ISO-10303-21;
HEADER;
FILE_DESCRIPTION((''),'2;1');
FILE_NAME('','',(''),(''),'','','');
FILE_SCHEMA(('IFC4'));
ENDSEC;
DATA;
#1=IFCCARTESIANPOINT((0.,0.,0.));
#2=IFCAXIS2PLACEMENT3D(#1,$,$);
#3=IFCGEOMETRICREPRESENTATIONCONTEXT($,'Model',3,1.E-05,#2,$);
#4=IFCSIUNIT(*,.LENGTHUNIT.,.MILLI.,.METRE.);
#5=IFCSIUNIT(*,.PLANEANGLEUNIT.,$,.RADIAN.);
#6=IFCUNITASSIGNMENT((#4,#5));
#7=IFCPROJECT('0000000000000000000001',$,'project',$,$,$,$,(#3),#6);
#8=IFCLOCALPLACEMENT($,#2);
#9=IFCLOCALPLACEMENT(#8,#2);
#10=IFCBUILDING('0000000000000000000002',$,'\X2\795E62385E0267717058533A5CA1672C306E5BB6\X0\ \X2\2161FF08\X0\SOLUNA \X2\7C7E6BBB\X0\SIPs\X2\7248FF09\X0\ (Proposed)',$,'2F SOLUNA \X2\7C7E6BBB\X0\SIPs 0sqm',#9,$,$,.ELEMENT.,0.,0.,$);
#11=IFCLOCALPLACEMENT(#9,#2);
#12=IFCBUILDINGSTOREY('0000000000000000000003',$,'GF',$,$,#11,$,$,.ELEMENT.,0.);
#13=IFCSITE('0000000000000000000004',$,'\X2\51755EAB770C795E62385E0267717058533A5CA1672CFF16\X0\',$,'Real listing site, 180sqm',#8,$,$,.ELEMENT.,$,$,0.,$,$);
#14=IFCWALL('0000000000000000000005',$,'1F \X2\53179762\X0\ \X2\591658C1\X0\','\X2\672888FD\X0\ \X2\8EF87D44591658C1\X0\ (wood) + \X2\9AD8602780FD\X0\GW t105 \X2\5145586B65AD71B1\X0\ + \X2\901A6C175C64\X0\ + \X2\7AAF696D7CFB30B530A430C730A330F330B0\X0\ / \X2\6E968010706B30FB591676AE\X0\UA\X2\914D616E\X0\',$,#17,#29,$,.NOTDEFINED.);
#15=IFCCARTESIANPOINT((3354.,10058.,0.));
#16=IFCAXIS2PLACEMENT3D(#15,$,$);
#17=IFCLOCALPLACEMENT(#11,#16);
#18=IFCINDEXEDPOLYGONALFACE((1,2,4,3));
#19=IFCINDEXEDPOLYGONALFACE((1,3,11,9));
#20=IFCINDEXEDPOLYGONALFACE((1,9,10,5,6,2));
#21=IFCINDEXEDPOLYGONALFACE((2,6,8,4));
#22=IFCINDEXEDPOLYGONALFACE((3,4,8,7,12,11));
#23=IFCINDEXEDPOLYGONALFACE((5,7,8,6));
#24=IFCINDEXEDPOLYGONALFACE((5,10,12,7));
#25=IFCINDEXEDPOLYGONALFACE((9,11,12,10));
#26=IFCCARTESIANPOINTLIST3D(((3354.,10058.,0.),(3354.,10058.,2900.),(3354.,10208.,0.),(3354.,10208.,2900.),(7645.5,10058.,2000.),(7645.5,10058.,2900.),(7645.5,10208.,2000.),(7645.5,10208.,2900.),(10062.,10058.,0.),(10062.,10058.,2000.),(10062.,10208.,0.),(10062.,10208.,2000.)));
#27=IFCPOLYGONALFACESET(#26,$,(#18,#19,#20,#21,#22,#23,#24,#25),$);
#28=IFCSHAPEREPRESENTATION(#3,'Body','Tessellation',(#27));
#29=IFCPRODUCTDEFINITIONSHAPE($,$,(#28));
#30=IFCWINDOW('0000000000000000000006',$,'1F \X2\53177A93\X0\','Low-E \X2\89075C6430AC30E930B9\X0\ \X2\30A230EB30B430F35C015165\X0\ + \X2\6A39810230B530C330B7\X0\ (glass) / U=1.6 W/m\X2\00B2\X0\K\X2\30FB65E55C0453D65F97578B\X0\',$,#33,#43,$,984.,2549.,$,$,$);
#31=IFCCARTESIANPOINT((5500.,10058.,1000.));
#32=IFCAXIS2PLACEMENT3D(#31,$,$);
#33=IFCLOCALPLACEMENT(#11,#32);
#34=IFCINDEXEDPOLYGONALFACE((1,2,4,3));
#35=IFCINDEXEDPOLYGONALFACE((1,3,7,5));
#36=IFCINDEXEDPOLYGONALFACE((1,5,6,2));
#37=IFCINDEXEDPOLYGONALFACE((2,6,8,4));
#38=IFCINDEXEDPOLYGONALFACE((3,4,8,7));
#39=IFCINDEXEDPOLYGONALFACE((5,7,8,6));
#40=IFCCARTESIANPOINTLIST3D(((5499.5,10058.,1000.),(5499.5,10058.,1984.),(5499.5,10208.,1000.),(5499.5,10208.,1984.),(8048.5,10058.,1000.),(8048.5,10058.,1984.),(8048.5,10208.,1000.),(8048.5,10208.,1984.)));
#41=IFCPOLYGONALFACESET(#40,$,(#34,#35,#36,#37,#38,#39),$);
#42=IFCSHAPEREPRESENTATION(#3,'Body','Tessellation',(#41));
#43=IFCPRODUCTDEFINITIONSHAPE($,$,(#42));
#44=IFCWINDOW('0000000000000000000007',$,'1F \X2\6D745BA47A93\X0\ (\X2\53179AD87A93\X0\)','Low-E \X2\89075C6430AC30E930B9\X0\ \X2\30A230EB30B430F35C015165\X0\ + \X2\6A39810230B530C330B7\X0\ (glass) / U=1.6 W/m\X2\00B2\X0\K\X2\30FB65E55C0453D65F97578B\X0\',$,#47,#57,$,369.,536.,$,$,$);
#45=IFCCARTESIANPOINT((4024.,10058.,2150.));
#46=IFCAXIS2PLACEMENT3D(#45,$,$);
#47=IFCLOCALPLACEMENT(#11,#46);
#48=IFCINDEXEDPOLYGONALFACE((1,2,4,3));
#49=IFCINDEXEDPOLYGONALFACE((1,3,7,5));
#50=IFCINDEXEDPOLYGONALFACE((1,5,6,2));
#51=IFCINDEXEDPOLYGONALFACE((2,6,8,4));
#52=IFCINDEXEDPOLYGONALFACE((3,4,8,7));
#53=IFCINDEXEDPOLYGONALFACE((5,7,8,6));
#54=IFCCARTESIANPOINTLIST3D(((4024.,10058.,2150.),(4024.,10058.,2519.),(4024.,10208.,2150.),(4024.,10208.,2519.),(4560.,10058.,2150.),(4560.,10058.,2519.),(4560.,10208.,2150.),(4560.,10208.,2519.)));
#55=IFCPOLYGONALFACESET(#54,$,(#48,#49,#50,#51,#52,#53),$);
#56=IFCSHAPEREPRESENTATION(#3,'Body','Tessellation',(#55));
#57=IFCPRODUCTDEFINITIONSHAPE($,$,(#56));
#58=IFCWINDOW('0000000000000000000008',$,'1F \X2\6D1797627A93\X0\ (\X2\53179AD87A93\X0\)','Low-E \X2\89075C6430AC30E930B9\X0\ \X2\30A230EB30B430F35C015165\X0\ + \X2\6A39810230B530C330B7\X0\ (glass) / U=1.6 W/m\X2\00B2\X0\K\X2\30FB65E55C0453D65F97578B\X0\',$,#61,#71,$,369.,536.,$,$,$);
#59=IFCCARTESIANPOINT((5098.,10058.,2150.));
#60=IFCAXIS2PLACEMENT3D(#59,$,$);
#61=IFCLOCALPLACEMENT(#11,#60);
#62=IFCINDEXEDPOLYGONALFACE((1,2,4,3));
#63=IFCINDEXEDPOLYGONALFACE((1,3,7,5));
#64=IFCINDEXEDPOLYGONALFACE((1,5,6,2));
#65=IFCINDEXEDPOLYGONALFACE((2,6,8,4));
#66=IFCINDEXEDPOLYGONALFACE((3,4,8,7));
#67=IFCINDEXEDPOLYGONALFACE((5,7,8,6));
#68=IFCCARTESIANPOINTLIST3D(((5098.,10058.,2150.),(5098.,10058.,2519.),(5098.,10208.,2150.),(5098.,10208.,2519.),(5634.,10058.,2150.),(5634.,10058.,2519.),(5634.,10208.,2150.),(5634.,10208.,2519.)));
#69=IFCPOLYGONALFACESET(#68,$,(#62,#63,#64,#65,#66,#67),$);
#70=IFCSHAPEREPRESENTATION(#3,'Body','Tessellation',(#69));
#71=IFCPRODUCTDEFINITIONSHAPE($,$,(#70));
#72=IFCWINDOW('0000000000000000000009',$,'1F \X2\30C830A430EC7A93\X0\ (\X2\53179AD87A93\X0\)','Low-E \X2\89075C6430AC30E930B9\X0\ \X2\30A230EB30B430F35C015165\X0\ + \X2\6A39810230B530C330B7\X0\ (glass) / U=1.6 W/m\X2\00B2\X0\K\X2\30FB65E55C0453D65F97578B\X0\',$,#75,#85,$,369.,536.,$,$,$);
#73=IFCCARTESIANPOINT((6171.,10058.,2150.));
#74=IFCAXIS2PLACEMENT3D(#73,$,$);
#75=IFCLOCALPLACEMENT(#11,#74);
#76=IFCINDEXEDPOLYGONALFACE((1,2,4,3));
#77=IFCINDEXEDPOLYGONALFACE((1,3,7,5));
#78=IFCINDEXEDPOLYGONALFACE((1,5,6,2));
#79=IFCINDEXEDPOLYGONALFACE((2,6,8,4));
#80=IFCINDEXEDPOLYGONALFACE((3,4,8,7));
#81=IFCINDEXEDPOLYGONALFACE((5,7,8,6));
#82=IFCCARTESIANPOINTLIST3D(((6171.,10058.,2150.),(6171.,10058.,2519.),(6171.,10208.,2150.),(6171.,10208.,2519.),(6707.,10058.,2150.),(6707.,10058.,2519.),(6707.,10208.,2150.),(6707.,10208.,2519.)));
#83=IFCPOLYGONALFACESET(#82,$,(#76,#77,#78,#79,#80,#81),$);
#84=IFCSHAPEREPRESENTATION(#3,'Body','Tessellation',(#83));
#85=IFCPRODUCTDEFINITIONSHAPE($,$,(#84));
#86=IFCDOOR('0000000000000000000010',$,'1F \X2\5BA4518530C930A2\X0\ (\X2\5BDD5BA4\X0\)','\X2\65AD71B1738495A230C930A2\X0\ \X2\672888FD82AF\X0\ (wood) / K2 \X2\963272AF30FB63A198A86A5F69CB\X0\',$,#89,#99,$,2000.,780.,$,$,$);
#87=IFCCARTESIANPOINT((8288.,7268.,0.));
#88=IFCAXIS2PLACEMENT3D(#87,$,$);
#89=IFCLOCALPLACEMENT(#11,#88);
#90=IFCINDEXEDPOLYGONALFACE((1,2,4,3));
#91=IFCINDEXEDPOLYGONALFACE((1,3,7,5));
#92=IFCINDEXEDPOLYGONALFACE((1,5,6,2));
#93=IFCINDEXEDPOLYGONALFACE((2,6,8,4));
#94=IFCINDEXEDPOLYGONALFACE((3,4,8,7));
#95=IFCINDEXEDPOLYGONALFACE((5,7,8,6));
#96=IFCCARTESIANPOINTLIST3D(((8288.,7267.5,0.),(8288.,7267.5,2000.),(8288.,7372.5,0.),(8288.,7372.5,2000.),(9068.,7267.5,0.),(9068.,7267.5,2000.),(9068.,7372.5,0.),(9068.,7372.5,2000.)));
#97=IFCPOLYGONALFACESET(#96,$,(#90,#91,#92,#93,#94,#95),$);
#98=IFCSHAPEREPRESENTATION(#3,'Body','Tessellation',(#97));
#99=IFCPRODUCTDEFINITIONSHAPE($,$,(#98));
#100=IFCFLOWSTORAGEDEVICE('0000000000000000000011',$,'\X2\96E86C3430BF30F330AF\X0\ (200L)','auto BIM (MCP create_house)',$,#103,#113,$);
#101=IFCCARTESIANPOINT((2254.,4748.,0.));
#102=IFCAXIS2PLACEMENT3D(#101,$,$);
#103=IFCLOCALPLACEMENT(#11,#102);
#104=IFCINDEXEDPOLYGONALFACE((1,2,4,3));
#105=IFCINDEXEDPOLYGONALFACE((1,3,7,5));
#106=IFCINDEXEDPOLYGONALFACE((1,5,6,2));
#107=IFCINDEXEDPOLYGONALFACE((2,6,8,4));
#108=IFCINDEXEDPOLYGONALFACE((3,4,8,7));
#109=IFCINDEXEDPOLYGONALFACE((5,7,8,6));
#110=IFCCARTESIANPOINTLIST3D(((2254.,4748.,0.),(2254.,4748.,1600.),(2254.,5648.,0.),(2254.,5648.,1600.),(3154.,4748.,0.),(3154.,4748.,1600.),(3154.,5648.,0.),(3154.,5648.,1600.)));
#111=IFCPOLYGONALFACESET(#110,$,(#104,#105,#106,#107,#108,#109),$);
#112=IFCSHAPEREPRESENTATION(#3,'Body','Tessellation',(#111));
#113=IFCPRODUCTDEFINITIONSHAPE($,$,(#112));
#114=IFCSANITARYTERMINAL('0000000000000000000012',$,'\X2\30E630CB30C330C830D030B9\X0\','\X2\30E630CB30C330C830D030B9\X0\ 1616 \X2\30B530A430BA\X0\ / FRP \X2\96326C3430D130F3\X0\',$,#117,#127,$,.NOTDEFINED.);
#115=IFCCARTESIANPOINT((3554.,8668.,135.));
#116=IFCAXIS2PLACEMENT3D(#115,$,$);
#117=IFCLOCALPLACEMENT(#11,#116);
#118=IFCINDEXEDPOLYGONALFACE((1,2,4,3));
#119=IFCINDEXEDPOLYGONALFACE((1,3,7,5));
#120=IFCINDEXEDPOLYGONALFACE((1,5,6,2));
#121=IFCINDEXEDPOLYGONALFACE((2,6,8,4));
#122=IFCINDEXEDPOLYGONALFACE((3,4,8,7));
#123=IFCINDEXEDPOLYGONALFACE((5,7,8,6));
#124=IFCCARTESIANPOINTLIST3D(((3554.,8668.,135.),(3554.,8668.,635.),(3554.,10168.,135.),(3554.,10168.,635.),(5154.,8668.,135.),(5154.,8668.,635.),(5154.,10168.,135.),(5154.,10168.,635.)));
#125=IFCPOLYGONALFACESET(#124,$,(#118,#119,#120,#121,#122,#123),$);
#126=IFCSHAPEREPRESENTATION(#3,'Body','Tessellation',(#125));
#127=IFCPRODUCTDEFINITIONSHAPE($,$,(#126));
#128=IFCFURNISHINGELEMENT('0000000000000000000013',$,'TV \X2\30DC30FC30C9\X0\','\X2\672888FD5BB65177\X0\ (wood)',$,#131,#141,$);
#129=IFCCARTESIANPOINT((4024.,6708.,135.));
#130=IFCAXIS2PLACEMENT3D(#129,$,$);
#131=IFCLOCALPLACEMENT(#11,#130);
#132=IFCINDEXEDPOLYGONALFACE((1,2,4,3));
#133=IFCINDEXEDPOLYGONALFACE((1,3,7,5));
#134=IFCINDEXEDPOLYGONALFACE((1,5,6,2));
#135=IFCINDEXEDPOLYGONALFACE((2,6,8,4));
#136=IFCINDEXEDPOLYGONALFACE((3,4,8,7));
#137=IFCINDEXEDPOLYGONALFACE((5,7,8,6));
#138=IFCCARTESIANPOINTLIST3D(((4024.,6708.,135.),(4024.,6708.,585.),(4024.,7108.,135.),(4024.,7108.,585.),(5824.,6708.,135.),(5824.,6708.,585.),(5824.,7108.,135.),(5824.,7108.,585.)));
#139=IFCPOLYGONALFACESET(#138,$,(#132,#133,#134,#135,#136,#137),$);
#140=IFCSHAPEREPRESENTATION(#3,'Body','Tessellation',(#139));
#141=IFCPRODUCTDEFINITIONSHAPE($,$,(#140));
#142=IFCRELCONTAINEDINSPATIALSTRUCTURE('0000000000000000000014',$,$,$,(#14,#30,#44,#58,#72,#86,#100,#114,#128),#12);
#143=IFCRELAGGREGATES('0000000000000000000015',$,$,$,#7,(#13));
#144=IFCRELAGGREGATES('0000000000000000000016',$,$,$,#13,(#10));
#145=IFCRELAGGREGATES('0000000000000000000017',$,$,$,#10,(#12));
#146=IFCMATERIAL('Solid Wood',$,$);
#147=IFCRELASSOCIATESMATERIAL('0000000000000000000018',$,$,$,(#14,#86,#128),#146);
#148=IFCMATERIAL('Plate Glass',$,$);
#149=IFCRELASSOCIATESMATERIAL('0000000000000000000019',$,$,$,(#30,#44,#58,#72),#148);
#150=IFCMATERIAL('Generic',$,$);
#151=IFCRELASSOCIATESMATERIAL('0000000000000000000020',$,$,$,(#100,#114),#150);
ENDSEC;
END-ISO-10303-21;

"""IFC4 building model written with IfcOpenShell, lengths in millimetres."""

from ifc_helpers import new_model, si_unit, frame, frame_2d, origin, place, context, project, spatial, rectangle, extrude, material, element, fill, save


model = new_model("IFC4")

# Units and contexts
model_context = context("Model", 3, precision=1e-05, world=origin())
ifc_project = project(units=[si_unit("LENGTHUNIT", "METRE", prefix="MILLI"), si_unit("PLANEANGLEUNIT", "RADIAN")], contexts=[model_context])

# Site, building, storey
site_placement = place(None, origin())
site = spatial("IfcSite", under=ifc_project, at=site_placement, Name="兵庫県神戸市東灘区岡本６", ObjectType="Real listing site, 180sqm", CompositionType="ELEMENT", RefElevation=0.0)
building_placement = place(site_placement, origin())
building = spatial("IfcBuilding", under=site, at=building_placement, Name="神戸市東灘区岡本の家 Ⅱ（SOLUNA 籾殻SIPs版） (Proposed)", ObjectType="2F SOLUNA 籾殻SIPs 0sqm", CompositionType="ELEMENT", ElevationOfRefHeight=0.0, ElevationOfTerrain=0.0)
storey_placement = place(building_placement, origin())
storey = spatial("IfcBuildingStorey", under=building, at=storey_placement, Name="GF", CompositionType="ELEMENT", Elevation=0.0)

# Wall, openings, windows
ifc_material_1 = material(Name="Solid Wood")
wall_1_placement = place(storey_placement, frame((3354.0, 10058.0, 0.0)))
wall_1 = element("IfcWall", 1, at=wall_1_placement, inside=storey, material=ifc_material_1, Name="1F 北面 外壁", Description="木製 軸組外壁 (wood) + 高性能GW t105 充填断熱 + 通気層 + 窯業系サイディング / 準耐火・外皮UA配慮", PredefinedType="NOTDEFINED", context=model_context, shape_type="SweptSolid", body=[
    extrude(rectangle(XDim=6708.0, YDim=150.0, at=frame_2d((3354.0, 75.0))), frame((3354.0, 10058.0, 0.0)), (0.0, 0.0, 1.0), 2900.0),
])
opening_1_placement = place(storey_placement, frame((5500.0, 10058.0, 1000.0)))
opening_1 = element("IfcOpeningElement", 2, at=opening_1_placement, cuts=wall_1, PredefinedType="NOTDEFINED", context=model_context, shape_type="SweptSolid", body=[
    extrude(rectangle(XDim=2549.0, YDim=150.0, at=frame_2d((1274.0, 75.0))), frame((5500.0, 10058.0, 1000.0)), (0.0, 0.0, 1.0), 984.0),
])
opening_2_placement = place(storey_placement, frame((4024.0, 10058.0, 2150.0)))
opening_2 = element("IfcOpeningElement", 3, at=opening_2_placement, cuts=wall_1, PredefinedType="NOTDEFINED", context=model_context, shape_type="SweptSolid", body=[
    extrude(rectangle(XDim=536.0, YDim=150.0, at=frame_2d((268.0, 75.0))), frame((4024.0, 10058.0, 2150.0)), (0.0, 0.0, 1.0), 369.0),
])
opening_3_placement = place(storey_placement, frame((5098.0, 10058.0, 2150.0)))
opening_3 = element("IfcOpeningElement", 4, at=opening_3_placement, cuts=wall_1, PredefinedType="NOTDEFINED", context=model_context, shape_type="SweptSolid", body=[
    extrude(rectangle(XDim=536.0, YDim=150.0, at=frame_2d((268.0, 75.0))), frame((5098.0, 10058.0, 2150.0)), (0.0, 0.0, 1.0), 369.0),
])
opening_4_placement = place(storey_placement, frame((6171.0, 10058.0, 2150.0)))
opening_4 = element("IfcOpeningElement", 5, at=opening_4_placement, cuts=wall_1, PredefinedType="NOTDEFINED", context=model_context, shape_type="SweptSolid", body=[
    extrude(rectangle(XDim=536.0, YDim=150.0, at=frame_2d((268.0, 75.0))), frame((6171.0, 10058.0, 2150.0)), (0.0, 0.0, 1.0), 369.0),
])
ifc_material_2 = material(Name="Plate Glass")
window_1_placement = place(storey_placement, frame((5500.0, 10058.0, 1000.0)))
window_1 = element("IfcWindow", 6, at=window_1_placement, inside=storey, material=ifc_material_2, Name="1F 北窓", Description="Low-E 複層ガラス アルゴン封入 + 樹脂サッシ (glass) / U=1.6 W/m²K・日射取得型", OverallHeight=984.0, OverallWidth=2549.0, context=model_context, shape_type="SweptSolid", body=[
    extrude(rectangle(XDim=2549.0, YDim=150.0, at=frame_2d((1274.0, 75.0))), frame((5500.0, 10058.0, 1000.0)), (0.0, 0.0, 1.0), 984.0),
])
fill(opening_1, window_1)
window_2_placement = place(storey_placement, frame((4024.0, 10058.0, 2150.0)))
window_2 = element("IfcWindow", 7, at=window_2_placement, inside=storey, material=ifc_material_2, Name="1F 浴室窓 (北高窓)", Description="Low-E 複層ガラス アルゴン封入 + 樹脂サッシ (glass) / U=1.6 W/m²K・日射取得型", OverallHeight=369.0, OverallWidth=536.0, context=model_context, shape_type="SweptSolid", body=[
    extrude(rectangle(XDim=536.0, YDim=150.0, at=frame_2d((268.0, 75.0))), frame((4024.0, 10058.0, 2150.0)), (0.0, 0.0, 1.0), 369.0),
])
fill(opening_2, window_2)
window_3_placement = place(storey_placement, frame((5098.0, 10058.0, 2150.0)))
window_3 = element("IfcWindow", 8, at=window_3_placement, inside=storey, material=ifc_material_2, Name="1F 洗面窓 (北高窓)", Description="Low-E 複層ガラス アルゴン封入 + 樹脂サッシ (glass) / U=1.6 W/m²K・日射取得型", OverallHeight=369.0, OverallWidth=536.0, context=model_context, shape_type="SweptSolid", body=[
    extrude(rectangle(XDim=536.0, YDim=150.0, at=frame_2d((268.0, 75.0))), frame((5098.0, 10058.0, 2150.0)), (0.0, 0.0, 1.0), 369.0),
])
fill(opening_3, window_3)
window_4_placement = place(storey_placement, frame((6171.0, 10058.0, 2150.0)))
window_4 = element("IfcWindow", 9, at=window_4_placement, inside=storey, material=ifc_material_2, Name="1F トイレ窓 (北高窓)", Description="Low-E 複層ガラス アルゴン封入 + 樹脂サッシ (glass) / U=1.6 W/m²K・日射取得型", OverallHeight=369.0, OverallWidth=536.0, context=model_context, shape_type="SweptSolid", body=[
    extrude(rectangle(XDim=536.0, YDim=150.0, at=frame_2d((268.0, 75.0))), frame((6171.0, 10058.0, 2150.0)), (0.0, 0.0, 1.0), 369.0),
])
fill(opening_4, window_4)

# Door
door_1_placement = place(storey_placement, frame((8288.0, 7268.0, 0.0)))
element("IfcDoor", 10, at=door_1_placement, inside=storey, material=ifc_material_1, Name="1F 室内ドア (寝室)", Description="断熱玄関ドア 木製芯 (wood) / K2 防犯・採風機構", OverallHeight=2000.0, OverallWidth=780.0, context=model_context, shape_type="SweptSolid", body=[
    extrude(rectangle(XDim=780.0, YDim=105.0, at=frame_2d((390.0, 52.0))), frame((8288.0, 7268.0, 0.0)), (0.0, 0.0, 1.0), 2000.0),
])

# Flow storage device
ifc_material_3 = material(Name="Generic")
flow_storage_device_placement = place(storey_placement, frame((2254.0, 4748.0, 0.0)))
element("IfcFlowStorageDevice", 11, at=flow_storage_device_placement, inside=storey, material=ifc_material_3, Name="雨水タンク (200L)", Description="auto BIM (MCP create_house)", context=model_context, shape_type="SweptSolid", body=[
    extrude(rectangle(XDim=900.0, YDim=900.0, at=frame_2d((450.0, 450.0))), frame((2254.0, 4748.0, 0.0)), (0.0, 0.0, 1.0), 1600.0),
])

# Sanitary terminal
sanitary_terminal_placement = place(storey_placement, frame((3554.0, 8668.0, 135.0)))
element("IfcSanitaryTerminal", 12, at=sanitary_terminal_placement, inside=storey, material=ifc_material_3, Name="ユニットバス", Description="ユニットバス 1616 サイズ / FRP 防水パン", PredefinedType="NOTDEFINED", context=model_context, shape_type="SweptSolid", body=[
    extrude(rectangle(XDim=1600.0, YDim=1500.0, at=frame_2d((800.0, 750.0))), frame((3554.0, 8668.0, 135.0)), (0.0, 0.0, 1.0), 500.0),
])

# Furnishing element
furnishing_placement = place(storey_placement, frame((4024.0, 6708.0, 135.0)))
element("IfcFurnishingElement", 13, at=furnishing_placement, inside=storey, material=ifc_material_1, Name="TV ボード", Description="木製家具 (wood)", context=model_context, shape_type="SweptSolid", body=[
    extrude(rectangle(XDim=1800.0, YDim=400.0, at=frame_2d((900.0, 200.0))), frame((4024.0, 6708.0, 135.0)), (0.0, 0.0, 1.0), 450.0),
])

save(model, "model.ifc")
